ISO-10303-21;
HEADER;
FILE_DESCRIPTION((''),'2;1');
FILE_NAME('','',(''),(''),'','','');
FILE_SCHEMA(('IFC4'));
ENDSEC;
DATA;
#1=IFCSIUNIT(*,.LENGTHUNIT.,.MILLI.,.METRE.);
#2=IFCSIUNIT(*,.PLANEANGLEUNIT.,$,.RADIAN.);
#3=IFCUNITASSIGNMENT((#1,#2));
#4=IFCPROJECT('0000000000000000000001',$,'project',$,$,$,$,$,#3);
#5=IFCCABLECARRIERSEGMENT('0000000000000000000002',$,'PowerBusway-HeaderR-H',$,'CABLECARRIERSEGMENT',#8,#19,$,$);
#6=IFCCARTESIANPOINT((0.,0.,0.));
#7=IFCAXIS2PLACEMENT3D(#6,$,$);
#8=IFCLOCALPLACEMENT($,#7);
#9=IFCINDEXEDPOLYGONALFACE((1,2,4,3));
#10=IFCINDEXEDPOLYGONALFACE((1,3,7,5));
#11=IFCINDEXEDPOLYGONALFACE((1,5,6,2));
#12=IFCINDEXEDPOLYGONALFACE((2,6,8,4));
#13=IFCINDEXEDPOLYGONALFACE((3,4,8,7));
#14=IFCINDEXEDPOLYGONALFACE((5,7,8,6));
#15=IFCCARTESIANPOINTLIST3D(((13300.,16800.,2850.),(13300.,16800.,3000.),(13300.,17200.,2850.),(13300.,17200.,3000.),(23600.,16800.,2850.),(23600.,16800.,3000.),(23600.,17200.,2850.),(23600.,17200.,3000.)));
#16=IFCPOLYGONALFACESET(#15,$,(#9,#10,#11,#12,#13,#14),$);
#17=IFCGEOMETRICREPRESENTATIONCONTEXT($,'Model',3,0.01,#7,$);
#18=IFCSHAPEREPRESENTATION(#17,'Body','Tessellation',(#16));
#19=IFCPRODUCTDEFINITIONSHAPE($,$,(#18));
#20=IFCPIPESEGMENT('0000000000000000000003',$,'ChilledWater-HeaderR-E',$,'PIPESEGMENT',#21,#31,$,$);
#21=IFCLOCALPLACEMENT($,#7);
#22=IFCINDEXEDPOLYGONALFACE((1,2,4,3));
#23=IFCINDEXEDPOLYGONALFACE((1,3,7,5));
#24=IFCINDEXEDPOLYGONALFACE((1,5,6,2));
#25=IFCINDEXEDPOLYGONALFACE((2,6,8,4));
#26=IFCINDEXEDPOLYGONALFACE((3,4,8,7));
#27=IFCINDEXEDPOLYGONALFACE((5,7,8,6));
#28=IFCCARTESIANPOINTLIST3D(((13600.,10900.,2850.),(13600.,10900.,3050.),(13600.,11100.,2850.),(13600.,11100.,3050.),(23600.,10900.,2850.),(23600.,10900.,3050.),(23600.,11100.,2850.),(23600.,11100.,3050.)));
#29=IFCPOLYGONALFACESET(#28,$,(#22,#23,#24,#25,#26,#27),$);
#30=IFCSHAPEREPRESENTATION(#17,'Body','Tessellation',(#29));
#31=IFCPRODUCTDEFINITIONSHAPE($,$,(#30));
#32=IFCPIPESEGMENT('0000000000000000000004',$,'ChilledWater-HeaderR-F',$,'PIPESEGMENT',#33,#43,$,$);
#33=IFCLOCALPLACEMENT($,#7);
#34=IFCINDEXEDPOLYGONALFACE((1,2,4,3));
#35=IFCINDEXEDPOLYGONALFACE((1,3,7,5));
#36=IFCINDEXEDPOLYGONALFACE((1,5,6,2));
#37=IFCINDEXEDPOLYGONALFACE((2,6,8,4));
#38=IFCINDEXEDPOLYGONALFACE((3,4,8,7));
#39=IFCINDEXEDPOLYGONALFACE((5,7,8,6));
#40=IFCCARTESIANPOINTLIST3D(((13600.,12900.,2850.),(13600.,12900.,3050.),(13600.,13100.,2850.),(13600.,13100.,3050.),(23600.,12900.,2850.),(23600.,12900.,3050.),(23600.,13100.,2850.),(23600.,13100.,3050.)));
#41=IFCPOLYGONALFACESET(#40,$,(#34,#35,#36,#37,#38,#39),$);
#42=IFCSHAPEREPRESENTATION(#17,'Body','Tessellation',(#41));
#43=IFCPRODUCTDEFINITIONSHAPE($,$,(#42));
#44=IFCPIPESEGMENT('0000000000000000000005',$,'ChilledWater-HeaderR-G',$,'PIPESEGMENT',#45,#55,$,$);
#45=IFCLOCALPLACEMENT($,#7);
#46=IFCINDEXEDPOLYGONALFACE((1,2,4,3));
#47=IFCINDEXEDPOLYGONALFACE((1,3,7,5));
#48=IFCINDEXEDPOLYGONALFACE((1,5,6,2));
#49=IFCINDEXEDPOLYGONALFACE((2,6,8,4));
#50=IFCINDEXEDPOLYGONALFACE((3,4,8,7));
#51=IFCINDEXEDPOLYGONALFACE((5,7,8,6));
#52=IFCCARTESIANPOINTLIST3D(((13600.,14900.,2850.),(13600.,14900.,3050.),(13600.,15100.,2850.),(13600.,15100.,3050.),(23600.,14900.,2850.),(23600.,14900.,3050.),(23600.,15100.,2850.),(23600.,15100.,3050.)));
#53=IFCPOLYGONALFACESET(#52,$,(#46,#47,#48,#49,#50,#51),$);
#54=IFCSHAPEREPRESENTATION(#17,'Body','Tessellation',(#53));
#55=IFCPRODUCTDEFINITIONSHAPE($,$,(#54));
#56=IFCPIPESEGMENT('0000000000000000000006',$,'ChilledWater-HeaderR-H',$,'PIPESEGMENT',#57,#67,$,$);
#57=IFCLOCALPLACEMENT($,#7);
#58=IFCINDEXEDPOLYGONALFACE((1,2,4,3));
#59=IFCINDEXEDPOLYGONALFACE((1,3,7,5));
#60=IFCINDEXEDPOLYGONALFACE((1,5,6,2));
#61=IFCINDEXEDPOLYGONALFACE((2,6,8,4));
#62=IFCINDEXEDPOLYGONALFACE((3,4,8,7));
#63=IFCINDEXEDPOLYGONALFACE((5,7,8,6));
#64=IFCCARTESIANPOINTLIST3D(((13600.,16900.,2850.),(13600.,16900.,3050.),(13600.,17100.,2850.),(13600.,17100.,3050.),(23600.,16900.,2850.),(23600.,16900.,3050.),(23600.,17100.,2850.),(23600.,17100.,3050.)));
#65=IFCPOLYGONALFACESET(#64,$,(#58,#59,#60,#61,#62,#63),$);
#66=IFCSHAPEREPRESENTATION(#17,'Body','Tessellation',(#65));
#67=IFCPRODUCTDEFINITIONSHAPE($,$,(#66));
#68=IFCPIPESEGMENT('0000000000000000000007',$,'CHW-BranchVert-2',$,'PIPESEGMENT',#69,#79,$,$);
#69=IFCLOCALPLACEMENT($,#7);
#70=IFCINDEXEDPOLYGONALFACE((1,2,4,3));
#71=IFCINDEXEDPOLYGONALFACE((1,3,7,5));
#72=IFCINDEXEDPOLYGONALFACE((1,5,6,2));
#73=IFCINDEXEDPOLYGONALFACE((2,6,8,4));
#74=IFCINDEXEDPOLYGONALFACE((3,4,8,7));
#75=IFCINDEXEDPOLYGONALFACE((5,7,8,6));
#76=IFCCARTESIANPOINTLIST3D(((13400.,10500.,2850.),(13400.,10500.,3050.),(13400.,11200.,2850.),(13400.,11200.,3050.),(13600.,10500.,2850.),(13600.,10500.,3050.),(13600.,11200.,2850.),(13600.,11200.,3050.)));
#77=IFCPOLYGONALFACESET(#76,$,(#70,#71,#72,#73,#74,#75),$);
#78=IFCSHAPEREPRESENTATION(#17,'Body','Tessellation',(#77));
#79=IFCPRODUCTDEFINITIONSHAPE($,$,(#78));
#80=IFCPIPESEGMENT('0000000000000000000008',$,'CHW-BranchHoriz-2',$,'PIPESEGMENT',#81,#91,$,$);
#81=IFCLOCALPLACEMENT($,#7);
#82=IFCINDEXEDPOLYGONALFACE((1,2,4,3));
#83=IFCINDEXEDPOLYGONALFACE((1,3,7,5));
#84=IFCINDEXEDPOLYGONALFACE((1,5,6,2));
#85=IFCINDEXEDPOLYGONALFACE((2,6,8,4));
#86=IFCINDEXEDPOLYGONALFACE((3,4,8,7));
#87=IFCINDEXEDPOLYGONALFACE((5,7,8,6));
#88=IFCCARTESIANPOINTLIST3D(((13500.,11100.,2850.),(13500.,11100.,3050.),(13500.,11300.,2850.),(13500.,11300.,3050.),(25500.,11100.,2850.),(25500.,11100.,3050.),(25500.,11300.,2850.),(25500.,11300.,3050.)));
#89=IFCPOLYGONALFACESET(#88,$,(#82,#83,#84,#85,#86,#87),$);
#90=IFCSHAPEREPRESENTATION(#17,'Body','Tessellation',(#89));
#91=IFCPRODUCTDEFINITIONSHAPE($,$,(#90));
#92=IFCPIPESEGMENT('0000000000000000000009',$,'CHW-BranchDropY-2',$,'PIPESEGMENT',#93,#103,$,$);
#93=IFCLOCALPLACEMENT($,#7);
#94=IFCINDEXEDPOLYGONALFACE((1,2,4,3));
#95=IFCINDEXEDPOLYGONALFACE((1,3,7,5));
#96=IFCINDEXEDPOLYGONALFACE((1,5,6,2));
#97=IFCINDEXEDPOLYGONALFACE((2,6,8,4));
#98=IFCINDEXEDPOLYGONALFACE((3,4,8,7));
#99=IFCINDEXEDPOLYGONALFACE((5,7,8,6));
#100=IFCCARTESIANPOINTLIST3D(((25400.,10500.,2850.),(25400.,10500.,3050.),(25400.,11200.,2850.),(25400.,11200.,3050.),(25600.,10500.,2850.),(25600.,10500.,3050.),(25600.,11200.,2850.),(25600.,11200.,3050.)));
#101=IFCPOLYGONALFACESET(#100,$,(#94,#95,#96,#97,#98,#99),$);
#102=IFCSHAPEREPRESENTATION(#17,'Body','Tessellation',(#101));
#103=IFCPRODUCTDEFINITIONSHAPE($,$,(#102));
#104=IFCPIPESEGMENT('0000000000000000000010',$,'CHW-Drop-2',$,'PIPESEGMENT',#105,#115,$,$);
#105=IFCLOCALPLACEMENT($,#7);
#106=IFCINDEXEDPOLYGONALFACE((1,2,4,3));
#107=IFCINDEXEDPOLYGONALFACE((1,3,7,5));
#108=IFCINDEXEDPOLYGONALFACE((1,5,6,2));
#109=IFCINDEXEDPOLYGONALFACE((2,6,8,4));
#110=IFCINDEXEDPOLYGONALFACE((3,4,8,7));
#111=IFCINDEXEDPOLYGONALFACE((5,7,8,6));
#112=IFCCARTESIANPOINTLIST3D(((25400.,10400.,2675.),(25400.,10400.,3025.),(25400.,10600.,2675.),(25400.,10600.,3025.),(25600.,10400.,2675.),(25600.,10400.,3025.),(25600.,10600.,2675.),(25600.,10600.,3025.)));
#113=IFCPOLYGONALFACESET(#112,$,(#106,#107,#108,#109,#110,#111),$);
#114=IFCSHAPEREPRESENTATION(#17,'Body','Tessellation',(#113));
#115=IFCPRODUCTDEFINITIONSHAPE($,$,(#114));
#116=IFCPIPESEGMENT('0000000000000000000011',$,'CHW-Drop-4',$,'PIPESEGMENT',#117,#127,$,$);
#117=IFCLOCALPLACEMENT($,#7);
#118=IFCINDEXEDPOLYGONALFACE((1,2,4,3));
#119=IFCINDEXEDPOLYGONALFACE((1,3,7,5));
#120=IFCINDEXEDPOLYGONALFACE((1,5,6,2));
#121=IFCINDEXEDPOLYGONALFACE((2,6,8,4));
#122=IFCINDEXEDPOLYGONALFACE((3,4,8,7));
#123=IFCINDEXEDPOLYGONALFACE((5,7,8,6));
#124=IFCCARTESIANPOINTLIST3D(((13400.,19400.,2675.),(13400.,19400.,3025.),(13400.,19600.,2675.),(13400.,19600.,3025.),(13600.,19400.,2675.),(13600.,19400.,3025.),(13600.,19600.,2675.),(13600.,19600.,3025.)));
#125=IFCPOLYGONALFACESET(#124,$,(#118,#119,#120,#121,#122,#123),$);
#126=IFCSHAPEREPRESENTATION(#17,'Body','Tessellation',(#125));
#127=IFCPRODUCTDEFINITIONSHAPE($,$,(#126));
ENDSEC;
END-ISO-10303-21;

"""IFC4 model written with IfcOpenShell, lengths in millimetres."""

from ifc_helpers import new_model, si_unit, frame, origin, place, context, project, polyline, outline, extrude, element, save


model = new_model("IFC4")

# Units and contexts
model_context = context("Model", 3, precision=0.01, world=origin())
ifc_project = project(units=[si_unit("LENGTHUNIT", "METRE", prefix="MILLI"), si_unit("PLANEANGLEUNIT", "RADIAN")])

# Cable carrier segment
for number, where, name in (
    (1, (18450.0, 17000.0, 2850.0), "PowerBusway-HeaderR-H"),
):
    element("IfcCableCarrierSegment", number, at=place(None, frame(where)), Name=name, ObjectType="CABLECARRIERSEGMENT", context=model_context, shape_type="SweptSolid", body=[
        extrude(outline(polyline([(-5150.0, -200.0), (5150.0, -200.0), (5150.0, 200.0), (-5150.0, 200.0), (-5150.0, -200.0)])), origin(), (0.0, 0.0, 1.0), 150.0),
    ])

# Pipe segments
for number, where, name in (
    (2, (18600.0, 11000.0, 2850.0), "ChilledWater-HeaderR-E"),
    (3, (18600.0, 13000.0, 2850.0), "ChilledWater-HeaderR-F"),
    (4, (18600.0, 15000.0, 2850.0), "ChilledWater-HeaderR-G"),
    (5, (18600.0, 17000.0, 2850.0), "ChilledWater-HeaderR-H"),
):
    element("IfcPipeSegment", number, at=place(None, frame(where)), Name=name, ObjectType="PIPESEGMENT", context=model_context, shape_type="SweptSolid", body=[
        extrude(outline(polyline([(-5000.0, -100.0), (5000.0, -100.0), (5000.0, 100.0), (-5000.0, 100.0), (-5000.0, -100.0)])), origin(), (0.0, 0.0, 1.0), 200.0),
    ])
pipe_segment_1_placement = place(None, frame((13500.0, 10850.0, 2850.0)))
element("IfcPipeSegment", 6, at=pipe_segment_1_placement, Name="CHW-BranchVert-2", ObjectType="PIPESEGMENT", context=model_context, shape_type="SweptSolid", body=[
    extrude(outline(polyline([(-100.0, -350.0), (100.0, -350.0), (100.0, 350.0), (-100.0, 350.0), (-100.0, -350.0)])), origin(), (0.0, 0.0, 1.0), 200.0),
])
pipe_segment_2_placement = place(None, frame((19500.0, 11200.0, 2850.0)))
element("IfcPipeSegment", 7, at=pipe_segment_2_placement, Name="CHW-BranchHoriz-2", ObjectType="PIPESEGMENT", context=model_context, shape_type="SweptSolid", body=[
    extrude(outline(polyline([(-6000.0, -100.0), (6000.0, -100.0), (6000.0, 100.0), (-6000.0, 100.0), (-6000.0, -100.0)])), origin(), (0.0, 0.0, 1.0), 200.0),
])
pipe_segment_3_placement = place(None, frame((25500.0, 10850.0, 2850.0)))
element("IfcPipeSegment", 8, at=pipe_segment_3_placement, Name="CHW-BranchDropY-2", ObjectType="PIPESEGMENT", context=model_context, shape_type="SweptSolid", body=[
    extrude(outline(polyline([(-100.0, -350.0), (100.0, -350.0), (100.0, 350.0), (-100.0, 350.0), (-100.0, -350.0)])), origin(), (0.0, 0.0, 1.0), 200.0),
])
for number, where, name in (
    (9, (25500.0, 10500.0, 2675.0), "CHW-Drop-2"),
    (10, (13500.0, 19500.0, 2675.0), "CHW-Drop-4"),
):
    element("IfcPipeSegment", number, at=place(None, frame(where)), Name=name, ObjectType="PIPESEGMENT", context=model_context, shape_type="SweptSolid", body=[
        extrude(outline(polyline([(-100.0, -100.0), (100.0, -100.0), (100.0, 100.0), (-100.0, 100.0), (-100.0, -100.0)])), origin(), (0.0, 0.0, 1.0), 350.0),
    ])

save(model, "model.ifc")
